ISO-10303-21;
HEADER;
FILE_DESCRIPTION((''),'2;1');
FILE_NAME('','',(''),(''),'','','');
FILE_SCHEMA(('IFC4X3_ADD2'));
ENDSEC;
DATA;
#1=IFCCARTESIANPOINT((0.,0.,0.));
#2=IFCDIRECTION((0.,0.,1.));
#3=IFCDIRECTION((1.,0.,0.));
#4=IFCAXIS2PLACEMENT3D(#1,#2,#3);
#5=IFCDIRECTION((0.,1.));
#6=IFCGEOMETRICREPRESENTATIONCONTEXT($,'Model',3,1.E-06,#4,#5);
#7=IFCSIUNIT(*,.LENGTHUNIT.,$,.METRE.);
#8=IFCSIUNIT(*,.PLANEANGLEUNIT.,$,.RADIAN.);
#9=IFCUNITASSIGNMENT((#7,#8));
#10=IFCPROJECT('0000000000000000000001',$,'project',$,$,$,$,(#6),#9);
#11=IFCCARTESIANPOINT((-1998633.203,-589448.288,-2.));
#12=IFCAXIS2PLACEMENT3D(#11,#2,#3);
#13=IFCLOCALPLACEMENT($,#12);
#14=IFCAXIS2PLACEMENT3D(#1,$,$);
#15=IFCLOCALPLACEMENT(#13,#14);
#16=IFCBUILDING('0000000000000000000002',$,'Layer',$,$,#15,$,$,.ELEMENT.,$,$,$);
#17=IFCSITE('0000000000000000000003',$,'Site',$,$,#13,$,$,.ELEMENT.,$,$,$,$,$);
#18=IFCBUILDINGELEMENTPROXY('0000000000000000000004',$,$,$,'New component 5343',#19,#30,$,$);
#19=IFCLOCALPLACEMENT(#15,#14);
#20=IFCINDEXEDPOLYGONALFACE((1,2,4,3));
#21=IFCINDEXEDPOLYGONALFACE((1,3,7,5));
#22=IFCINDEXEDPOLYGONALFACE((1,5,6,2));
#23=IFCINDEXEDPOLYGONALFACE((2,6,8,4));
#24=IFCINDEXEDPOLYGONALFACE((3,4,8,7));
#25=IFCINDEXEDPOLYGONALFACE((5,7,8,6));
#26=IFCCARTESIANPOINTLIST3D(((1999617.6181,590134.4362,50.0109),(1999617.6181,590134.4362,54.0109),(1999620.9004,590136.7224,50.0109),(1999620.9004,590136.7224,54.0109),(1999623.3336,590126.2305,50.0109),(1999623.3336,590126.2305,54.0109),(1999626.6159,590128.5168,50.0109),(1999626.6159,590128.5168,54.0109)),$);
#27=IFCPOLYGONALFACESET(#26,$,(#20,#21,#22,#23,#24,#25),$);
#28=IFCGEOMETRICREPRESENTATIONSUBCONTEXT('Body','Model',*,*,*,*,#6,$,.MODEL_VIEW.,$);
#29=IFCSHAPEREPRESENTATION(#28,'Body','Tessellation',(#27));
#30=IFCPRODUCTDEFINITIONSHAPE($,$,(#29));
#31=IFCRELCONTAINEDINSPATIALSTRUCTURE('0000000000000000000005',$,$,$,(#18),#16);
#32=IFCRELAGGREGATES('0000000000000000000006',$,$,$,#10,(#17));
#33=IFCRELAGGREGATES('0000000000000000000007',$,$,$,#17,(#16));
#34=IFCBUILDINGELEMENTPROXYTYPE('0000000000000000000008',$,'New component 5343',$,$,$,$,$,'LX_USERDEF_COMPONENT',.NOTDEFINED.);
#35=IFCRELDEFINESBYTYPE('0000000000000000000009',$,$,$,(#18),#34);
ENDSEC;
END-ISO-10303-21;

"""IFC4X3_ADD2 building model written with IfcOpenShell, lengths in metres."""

from ifc_helpers import new_model, si_unit, direction, frame, frame_2d, origin, origin_with_axes, place, context, subcontext, project, spatial, rectangle, extrude, type_object, element, save


model = new_model("IFC4X3_ADD2")

# Units and contexts
model_context = context("Model", 3, precision=1e-06, world=origin_with_axes(), true_north=direction((0.0, 1.0)))
body_context = subcontext(model_context, "Body", "Model", "MODEL_VIEW")
ifc_project = project(units=[si_unit("LENGTHUNIT", "METRE"), si_unit("PLANEANGLEUNIT", "RADIAN")], contexts=[model_context])

# Site, building
site_placement = place(None, frame((-1998633.203, -589448.288, -2.0), z_axis=(0.0, 0.0, 1.0), x_axis=(1.0, 0.0, 0.0)))
site = spatial("IfcSite", under=ifc_project, at=site_placement, Name="Site", CompositionType="ELEMENT")
building_placement = place(site_placement, origin())
building = spatial("IfcBuilding", under=site, at=building_placement, Name="Layer", CompositionType="ELEMENT")

# Building element proxy
building_element_proxy_type = type_object("IfcBuildingElementProxyType", Name="New component 5343", ElementType="LX_USERDEF_COMPONENT", PredefinedType="NOTDEFINED")
proxy_placement = place(building_placement, frame((1999617.6181, 590134.4362, 50.0109), z_axis=(0.0, 0.0, 1.0), x_axis=(0.571553, -0.820565, 0.0)))
element("IfcBuildingElementProxy", 1, at=proxy_placement, inside=building, type_object=building_element_proxy_type, ObjectType="New component 5343", context=body_context, shape_type="SweptSolid", body=[
    extrude(rectangle(XDim=10.0, YDim=4.0, at=frame_2d((5.0, 2.0), x_axis=(1.0, 0.0))), origin_with_axes(), (0.0, 0.0, 1.0), 4.0),
])

save(model, "model.ifc")
